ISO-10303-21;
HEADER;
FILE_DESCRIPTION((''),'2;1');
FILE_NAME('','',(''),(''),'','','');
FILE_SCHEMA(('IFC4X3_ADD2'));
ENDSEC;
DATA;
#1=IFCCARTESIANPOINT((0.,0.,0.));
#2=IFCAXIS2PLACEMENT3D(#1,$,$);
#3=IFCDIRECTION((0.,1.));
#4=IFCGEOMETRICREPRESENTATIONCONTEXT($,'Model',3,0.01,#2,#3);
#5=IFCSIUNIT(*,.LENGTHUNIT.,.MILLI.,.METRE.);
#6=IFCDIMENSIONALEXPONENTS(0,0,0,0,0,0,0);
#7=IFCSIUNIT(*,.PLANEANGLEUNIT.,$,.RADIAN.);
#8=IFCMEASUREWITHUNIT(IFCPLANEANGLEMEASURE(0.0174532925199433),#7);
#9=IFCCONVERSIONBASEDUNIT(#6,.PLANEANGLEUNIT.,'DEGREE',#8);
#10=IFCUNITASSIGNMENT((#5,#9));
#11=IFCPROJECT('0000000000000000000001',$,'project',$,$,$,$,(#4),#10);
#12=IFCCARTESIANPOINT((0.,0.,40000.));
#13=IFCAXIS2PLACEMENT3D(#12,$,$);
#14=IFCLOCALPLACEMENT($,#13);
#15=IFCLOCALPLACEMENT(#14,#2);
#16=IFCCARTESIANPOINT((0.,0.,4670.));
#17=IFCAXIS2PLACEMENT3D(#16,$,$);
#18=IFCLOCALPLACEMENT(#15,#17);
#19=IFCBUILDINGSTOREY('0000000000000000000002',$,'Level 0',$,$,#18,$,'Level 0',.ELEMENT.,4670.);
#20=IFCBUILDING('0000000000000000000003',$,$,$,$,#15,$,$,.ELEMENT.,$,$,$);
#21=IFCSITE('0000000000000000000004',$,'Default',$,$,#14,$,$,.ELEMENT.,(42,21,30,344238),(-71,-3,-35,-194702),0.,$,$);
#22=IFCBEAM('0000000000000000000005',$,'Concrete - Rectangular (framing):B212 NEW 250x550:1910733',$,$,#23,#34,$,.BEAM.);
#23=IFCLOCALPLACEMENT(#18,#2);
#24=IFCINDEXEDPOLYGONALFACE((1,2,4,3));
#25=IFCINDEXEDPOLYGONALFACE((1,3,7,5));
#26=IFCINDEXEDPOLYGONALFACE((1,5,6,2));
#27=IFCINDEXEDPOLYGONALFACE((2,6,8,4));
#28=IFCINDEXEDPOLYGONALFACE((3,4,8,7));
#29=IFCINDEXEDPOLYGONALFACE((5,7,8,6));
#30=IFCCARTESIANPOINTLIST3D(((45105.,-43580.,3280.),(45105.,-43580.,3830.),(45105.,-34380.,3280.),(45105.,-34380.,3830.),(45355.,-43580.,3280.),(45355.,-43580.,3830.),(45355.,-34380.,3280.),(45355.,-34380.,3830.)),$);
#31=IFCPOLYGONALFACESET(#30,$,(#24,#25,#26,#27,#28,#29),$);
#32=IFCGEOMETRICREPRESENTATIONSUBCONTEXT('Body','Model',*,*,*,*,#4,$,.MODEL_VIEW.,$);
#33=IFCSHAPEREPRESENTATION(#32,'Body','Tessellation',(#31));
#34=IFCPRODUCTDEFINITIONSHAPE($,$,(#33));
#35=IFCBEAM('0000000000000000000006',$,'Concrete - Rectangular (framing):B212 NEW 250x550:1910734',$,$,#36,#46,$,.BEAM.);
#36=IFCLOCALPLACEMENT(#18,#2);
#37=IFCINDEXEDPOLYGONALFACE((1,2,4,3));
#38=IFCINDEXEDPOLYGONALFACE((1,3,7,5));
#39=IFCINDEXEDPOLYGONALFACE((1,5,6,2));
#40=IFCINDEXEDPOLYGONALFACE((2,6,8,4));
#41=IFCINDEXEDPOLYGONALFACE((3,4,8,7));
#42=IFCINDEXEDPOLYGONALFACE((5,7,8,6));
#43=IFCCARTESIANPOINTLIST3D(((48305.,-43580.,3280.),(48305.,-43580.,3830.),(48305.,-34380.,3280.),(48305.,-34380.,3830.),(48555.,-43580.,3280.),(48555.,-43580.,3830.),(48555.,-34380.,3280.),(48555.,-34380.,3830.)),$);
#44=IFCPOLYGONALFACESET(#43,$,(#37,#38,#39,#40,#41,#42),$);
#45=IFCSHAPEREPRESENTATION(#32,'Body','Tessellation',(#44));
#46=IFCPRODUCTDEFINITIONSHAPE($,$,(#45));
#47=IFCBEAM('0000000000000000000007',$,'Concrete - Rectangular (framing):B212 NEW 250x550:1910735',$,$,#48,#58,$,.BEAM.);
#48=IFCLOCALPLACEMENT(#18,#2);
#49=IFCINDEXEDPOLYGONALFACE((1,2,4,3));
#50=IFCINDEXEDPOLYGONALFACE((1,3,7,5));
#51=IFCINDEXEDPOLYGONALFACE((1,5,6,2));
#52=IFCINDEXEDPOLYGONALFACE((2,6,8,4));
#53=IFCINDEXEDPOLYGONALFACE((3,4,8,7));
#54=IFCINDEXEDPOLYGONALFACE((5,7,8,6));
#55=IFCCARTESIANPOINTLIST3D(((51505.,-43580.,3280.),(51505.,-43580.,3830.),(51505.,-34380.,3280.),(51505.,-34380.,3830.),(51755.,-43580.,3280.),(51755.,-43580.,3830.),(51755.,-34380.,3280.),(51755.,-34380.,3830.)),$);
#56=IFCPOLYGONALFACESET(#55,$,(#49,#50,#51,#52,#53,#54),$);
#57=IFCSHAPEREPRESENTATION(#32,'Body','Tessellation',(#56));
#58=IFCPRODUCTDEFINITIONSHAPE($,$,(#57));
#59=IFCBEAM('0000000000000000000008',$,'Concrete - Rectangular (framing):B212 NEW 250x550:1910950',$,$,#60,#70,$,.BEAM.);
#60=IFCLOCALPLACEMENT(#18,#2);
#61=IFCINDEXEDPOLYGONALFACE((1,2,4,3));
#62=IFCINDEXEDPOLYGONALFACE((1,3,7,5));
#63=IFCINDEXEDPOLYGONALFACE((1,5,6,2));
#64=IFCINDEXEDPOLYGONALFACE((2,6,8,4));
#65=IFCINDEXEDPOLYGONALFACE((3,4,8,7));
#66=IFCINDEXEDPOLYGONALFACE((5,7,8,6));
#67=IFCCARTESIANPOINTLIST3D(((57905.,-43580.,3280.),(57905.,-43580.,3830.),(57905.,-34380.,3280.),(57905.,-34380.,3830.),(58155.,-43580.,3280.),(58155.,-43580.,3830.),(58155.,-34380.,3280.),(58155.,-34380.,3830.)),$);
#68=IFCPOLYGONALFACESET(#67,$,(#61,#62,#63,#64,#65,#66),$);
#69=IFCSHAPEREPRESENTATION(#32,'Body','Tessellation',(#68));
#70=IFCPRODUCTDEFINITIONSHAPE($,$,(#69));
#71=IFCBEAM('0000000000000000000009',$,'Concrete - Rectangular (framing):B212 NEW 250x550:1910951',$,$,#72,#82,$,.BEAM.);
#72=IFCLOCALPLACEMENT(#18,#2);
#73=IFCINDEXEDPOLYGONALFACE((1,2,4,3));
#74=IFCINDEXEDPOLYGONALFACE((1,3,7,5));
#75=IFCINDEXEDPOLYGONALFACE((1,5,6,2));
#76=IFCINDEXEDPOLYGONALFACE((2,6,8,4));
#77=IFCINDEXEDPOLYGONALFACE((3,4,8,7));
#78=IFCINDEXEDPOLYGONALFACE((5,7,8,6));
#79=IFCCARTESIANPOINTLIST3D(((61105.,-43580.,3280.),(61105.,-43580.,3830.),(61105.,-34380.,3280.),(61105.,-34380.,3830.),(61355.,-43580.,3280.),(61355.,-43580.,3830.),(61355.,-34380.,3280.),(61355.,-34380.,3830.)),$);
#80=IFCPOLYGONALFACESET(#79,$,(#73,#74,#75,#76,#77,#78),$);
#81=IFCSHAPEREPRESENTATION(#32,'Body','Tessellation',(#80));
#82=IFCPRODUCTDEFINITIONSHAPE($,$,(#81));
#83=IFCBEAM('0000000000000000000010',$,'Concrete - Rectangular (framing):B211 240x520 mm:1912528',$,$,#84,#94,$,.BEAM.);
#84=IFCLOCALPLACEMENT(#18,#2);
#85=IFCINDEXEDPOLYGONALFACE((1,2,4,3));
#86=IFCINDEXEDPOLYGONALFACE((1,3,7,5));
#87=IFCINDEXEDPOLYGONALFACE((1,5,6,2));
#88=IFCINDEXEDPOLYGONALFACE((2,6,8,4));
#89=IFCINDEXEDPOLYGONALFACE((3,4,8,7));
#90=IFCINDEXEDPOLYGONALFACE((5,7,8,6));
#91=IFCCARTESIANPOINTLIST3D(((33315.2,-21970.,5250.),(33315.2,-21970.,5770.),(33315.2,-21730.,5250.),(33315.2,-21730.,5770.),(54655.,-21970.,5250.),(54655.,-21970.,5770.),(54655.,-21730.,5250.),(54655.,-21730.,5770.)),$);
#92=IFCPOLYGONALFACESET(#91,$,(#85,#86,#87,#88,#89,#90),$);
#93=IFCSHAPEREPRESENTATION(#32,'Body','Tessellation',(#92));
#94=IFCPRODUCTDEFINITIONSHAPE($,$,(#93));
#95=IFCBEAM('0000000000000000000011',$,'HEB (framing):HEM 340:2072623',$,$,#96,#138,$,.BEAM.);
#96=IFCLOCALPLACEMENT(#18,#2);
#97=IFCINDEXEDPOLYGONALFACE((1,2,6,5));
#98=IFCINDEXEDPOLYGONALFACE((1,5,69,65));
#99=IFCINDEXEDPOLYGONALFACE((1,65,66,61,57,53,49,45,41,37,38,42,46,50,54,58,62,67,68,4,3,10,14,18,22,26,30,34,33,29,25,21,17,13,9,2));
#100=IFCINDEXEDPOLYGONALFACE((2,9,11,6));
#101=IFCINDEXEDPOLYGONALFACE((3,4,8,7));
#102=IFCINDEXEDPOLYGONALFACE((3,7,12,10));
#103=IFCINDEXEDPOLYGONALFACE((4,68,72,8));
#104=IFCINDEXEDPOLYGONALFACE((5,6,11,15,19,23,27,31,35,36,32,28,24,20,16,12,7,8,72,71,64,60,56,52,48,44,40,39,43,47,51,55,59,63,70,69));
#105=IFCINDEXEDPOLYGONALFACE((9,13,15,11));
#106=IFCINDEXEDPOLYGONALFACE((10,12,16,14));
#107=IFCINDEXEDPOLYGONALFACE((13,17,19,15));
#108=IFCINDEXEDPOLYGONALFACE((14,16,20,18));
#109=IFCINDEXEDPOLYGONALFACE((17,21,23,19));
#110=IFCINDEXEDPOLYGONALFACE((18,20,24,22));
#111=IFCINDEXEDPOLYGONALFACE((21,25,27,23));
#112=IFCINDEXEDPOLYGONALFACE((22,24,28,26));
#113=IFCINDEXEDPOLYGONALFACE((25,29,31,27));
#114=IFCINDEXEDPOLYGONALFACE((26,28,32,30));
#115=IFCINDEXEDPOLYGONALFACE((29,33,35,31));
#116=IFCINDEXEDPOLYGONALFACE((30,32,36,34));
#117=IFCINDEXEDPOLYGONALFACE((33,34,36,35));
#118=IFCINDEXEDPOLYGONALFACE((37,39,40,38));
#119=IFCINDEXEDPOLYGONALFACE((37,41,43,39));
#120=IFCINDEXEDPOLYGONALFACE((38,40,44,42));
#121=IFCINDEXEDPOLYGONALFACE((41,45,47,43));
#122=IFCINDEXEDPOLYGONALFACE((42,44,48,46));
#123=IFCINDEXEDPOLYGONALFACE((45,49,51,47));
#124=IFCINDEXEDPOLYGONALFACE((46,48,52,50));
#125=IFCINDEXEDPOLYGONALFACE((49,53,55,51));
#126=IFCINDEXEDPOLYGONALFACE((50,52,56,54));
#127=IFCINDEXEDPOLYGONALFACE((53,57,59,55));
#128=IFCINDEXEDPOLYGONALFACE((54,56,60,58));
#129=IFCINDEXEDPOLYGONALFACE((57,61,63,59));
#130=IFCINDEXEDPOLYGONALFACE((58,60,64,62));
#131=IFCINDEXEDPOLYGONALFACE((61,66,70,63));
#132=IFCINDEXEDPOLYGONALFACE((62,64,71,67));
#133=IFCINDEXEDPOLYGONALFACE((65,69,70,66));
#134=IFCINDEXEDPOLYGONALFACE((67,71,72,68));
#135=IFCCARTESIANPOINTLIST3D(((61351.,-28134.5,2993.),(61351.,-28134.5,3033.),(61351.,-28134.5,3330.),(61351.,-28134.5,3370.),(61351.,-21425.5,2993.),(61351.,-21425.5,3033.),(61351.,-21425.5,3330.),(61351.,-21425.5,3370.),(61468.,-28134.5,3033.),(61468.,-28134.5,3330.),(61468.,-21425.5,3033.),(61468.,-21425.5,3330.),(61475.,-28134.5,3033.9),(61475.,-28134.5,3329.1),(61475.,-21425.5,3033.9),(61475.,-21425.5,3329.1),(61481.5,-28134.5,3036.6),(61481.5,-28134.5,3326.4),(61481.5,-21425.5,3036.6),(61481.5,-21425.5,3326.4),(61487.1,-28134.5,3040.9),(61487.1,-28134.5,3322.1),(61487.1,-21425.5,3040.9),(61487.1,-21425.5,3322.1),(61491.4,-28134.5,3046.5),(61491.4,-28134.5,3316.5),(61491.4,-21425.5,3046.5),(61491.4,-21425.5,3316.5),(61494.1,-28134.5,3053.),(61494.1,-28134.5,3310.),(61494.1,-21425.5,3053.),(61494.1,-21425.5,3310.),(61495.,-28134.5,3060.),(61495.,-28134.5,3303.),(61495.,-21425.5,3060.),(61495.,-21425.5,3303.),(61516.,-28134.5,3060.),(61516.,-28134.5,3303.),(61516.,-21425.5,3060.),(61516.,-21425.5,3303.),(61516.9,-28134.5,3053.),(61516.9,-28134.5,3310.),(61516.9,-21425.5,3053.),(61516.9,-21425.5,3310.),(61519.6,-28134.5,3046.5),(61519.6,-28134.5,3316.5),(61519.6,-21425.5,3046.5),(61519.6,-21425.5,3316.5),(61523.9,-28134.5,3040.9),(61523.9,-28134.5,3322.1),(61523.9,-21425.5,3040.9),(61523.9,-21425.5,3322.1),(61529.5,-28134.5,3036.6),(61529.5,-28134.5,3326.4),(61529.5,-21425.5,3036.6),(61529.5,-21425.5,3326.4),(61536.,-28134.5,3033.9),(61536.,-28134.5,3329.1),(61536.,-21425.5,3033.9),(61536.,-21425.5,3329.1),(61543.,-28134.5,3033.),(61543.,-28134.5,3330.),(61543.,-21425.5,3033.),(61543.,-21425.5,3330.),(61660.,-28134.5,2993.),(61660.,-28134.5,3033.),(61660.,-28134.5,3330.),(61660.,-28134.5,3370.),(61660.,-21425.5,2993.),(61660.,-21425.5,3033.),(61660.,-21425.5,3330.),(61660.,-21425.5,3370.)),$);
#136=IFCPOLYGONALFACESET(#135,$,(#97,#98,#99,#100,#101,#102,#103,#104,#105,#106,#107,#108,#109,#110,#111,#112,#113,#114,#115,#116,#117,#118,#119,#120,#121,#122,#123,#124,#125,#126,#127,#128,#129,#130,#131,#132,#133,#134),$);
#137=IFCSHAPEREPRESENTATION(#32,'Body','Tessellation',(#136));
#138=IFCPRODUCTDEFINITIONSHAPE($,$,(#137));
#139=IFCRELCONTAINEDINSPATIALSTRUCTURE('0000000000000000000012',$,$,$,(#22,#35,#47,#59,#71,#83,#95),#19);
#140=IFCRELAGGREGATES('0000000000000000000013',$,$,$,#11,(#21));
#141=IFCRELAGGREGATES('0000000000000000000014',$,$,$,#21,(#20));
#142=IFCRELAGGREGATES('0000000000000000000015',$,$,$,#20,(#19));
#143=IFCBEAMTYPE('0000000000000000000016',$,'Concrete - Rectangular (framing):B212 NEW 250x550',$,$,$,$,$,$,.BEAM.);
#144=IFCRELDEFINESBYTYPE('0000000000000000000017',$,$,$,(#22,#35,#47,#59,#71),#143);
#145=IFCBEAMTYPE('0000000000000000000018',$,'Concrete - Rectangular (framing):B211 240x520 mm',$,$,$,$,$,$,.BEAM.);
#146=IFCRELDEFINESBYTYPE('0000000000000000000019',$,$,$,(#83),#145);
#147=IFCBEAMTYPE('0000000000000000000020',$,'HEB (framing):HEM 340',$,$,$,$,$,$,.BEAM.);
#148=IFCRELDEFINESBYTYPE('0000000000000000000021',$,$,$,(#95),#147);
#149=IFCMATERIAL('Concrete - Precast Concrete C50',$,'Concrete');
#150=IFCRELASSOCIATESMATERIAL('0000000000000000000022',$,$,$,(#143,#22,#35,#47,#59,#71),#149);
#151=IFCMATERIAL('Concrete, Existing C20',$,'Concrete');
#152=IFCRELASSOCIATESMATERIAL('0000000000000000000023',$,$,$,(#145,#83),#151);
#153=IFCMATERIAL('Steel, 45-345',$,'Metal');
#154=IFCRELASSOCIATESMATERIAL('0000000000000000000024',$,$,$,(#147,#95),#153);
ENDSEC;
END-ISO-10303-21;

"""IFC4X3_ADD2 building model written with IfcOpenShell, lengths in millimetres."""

from ifc_helpers import new_model, entity, si_unit, converted_unit, direction, frame, frame_2d, origin, origin_2d_with_axis, place, context, subcontext, project, spatial, polyline, circle_curve, parameter, trimmed, segment, composite_curve, rectangle, outline, extrude, source, transform, mapped, material, material_profile, profile_set, profile_usage, type_object, type_shapes, element, save


model = new_model("IFC4X3_ADD2")

# Units and contexts
model_context = context("Model", 3, precision=0.01, world=origin(), true_north=direction((0.0, 1.0)))
body_context = subcontext(model_context, "Body", "Model", "MODEL_VIEW")
ifc_project = project(units=[si_unit("LENGTHUNIT", "METRE", prefix="MILLI"), converted_unit("PLANEANGLEUNIT", "DEGREE", entity("IfcPlaneAngleMeasure", 0.0174532925199433), si_unit("PLANEANGLEUNIT", "RADIAN"), dimensions=[0, 0, 0, 0, 0, 0, 0])], contexts=[model_context])

# Site, building, storey
site_placement = place(None, frame((0.0, 0.0, 40000.0)))
site = spatial("IfcSite", under=ifc_project, at=site_placement, Name="Default", CompositionType="ELEMENT", RefLatitude=(42, 21, 30, 344238), RefLongitude=(-71, -3, -35, -194702), RefElevation=0.0)
building_placement = place(site_placement, origin())
building = spatial("IfcBuilding", under=site, at=building_placement, CompositionType="ELEMENT")
storey_placement = place(building_placement, frame((0.0, 0.0, 4670.0)))
storey = spatial("IfcBuildingStorey", under=building, at=storey_placement, Name="Level 0", LongName="Level 0", CompositionType="ELEMENT", Elevation=4670.0)

# Shared definitions
ifc_material_1 = material(Name="Steel, 45-345", Category="Metal")

# Beams
ifc_material_profile_1 = material_profile(ifc_material_1, outline(composite_curve([segment(polyline([(-154.5, -148.5), (-154.5, -188.5)]), True, "CONTINUOUS"), segment(polyline([(-154.5, -188.5), (154.5, -188.5)]), True, "CONTINUOUS"), segment(polyline([(154.5, -188.5), (154.5, -148.5)]), True, "CONTINUOUS"), segment(polyline([(154.5, -148.5), (37.5, -148.5)]), True, "CONTINUOUS"), segment(trimmed(circle_curve(frame_2d((37.5, -121.5), x_axis=(1.0, 0.0)), 27.0), [parameter(180.0)], [parameter(270.0)], True, "PARAMETER"), False, "CONTINUOUS"), segment(polyline([(10.5, -121.5), (10.5, 121.5)]), True, "CONTINUOUS"), segment(trimmed(circle_curve(frame_2d((37.5, 121.5), x_axis=(1.0, 0.0)), 27.0), [parameter(90.0)], [parameter(180.0)], True, "PARAMETER"), False, "CONTINUOUS"), segment(polyline([(37.5, 148.5), (154.5, 148.5)]), True, "CONTINUOUS"), segment(polyline([(154.5, 148.5), (154.5, 188.5)]), True, "CONTINUOUS"), segment(polyline([(154.5, 188.5), (-154.5, 188.5)]), True, "CONTINUOUS"), segment(polyline([(-154.5, 188.5), (-154.5, 148.5)]), True, "CONTINUOUS"), segment(polyline([(-154.5, 148.5), (-37.5, 148.5)]), True, "CONTINUOUS"), segment(trimmed(circle_curve(frame_2d((-37.5, 121.5), x_axis=(1.0, 0.0)), 27.0), [parameter(360.0)], [parameter(90.0)], True, "PARAMETER"), False, "CONTINUOUS"), segment(polyline([(-10.5, 121.5), (-10.5, -121.5)]), True, "CONTINUOUS"), segment(trimmed(circle_curve(frame_2d((-37.5, -121.5), x_axis=(1.0, 0.0)), 27.0), [parameter(270.0)], [parameter(0.0)], True, "PARAMETER"), False, "CONTINUOUS"), segment(polyline([(-37.5, -148.5), (-154.5, -148.5)]), True, "CONTINUOUS")], self_intersect=False)), Name="HEM 340")
ifc_profile_set_1 = profile_set([ifc_material_profile_1], Name="HEM 340")
ifc_profile_usage_1 = profile_usage(ifc_profile_set_1, cardinal=8)
ifc_material_2 = material(Name="Concrete - Precast Concrete C50", Category="Concrete")
ifc_material_profile_2 = material_profile(ifc_material_2, rectangle(XDim=9200.0, YDim=250.0, at=origin_2d_with_axis()), Name="B212 NEW 250x550")
ifc_profile_set_2 = profile_set([ifc_material_profile_2], Name="B212 NEW 250x550")
ifc_profile_usage_2 = profile_usage(ifc_profile_set_2, cardinal=8)
beam_type_1 = type_object("IfcBeamType", Name="Concrete - Rectangular (framing):B212 NEW 250x550", PredefinedType="BEAM", material=ifc_profile_set_2)
shared_shape_1 = source(origin(), body_context, "Body", "SweptSolid", [
    extrude(rectangle(XDim=9200.0, YDim=250.0, at=origin_2d_with_axis()), frame((0.0, 0.0, -275.0), z_axis=(0.0, 0.0, 1.0), x_axis=(-1.0, 0.0, 0.0)), (0.0, 0.0, 1.0), 550.0),
])
type_shapes(beam_type_1, [shared_shape_1])
for number, where, z_axis, x_axis, name in (
    (1, (45230.0, -38980.0, 3555.0), (0.0, 0.0, 1.0), (0.0, 1.0, 0.0), "Concrete - Rectangular (framing):B212 NEW 250x550:1910733"),
    (2, (48430.0, -38980.0, 3555.0), (0.0, 0.0, 1.0), (0.0, 1.0, 0.0), "Concrete - Rectangular (framing):B212 NEW 250x550:1910734"),
    (3, (51630.0, -38980.0, 3555.0), (0.0, 0.0, 1.0), (0.0, 1.0, 0.0), "Concrete - Rectangular (framing):B212 NEW 250x550:1910735"),
    (4, (58030.0, -38980.0, 3555.0), (0.0, 0.0, 1.0), (0.0, 1.0, 0.0), "Concrete - Rectangular (framing):B212 NEW 250x550:1910950"),
    (5, (61230.0, -38980.0, 3555.0), (0.0, 0.0, 1.0), (0.0, 1.0, 0.0), "Concrete - Rectangular (framing):B212 NEW 250x550:1910951"),
):
    element("IfcBeam", number, at=place(storey_placement, frame(where, z_axis=z_axis, x_axis=x_axis)), inside=storey, type_object=beam_type_1, material=ifc_profile_usage_2, Name=name, PredefinedType="BEAM", context=body_context, shape_type="MappedRepresentation", body=[
        mapped(shared_shape_1, transform((0.0, 0.0, 0.0), scale=1.0)),
    ])
ifc_material_3 = material(Name="Concrete, Existing C20", Category="Concrete")
ifc_material_profile_3 = material_profile(ifc_material_3, rectangle(XDim=21339.8, YDim=240.0, at=origin_2d_with_axis()), Name="B211 240x520 mm")
ifc_profile_set_3 = profile_set([ifc_material_profile_3], Name="B211 240x520 mm")
ifc_profile_usage_3 = profile_usage(ifc_profile_set_3, cardinal=8)
beam_type_2 = type_object("IfcBeamType", Name="Concrete - Rectangular (framing):B211 240x520 mm", PredefinedType="BEAM", material=ifc_profile_set_3)
shared_shape_2 = source(origin(), body_context, "Body", "SweptSolid", [
    extrude(rectangle(XDim=21339.8, YDim=240.0, at=origin_2d_with_axis()), frame((-60.1, 0.0, -260.0), z_axis=(0.0, 0.0, 1.0), x_axis=(-1.0, 0.0, 0.0)), (0.0, 0.0, 1.0), 520.0),
])
type_shapes(beam_type_2, [shared_shape_2])
beam_1_placement = place(storey_placement, frame((43925.0, -21850.0, 5510.0), z_axis=(0.0, 0.0, 1.0), x_axis=(-1.0, 0.0, 0.0)))
element("IfcBeam", 6, at=beam_1_placement, inside=storey, type_object=beam_type_2, material=ifc_profile_usage_3, Name="Concrete - Rectangular (framing):B211 240x520 mm:1912528", PredefinedType="BEAM", context=body_context, shape_type="MappedRepresentation", body=[
    mapped(shared_shape_2, transform((0.0, 0.0, 0.0), scale=1.0)),
])
beam_type_3 = type_object("IfcBeamType", Name="HEB (framing):HEM 340", PredefinedType="BEAM", material=ifc_profile_set_1)
shared_shape_3 = source(origin(), body_context, "Body", "SweptSolid", [
    extrude(outline(composite_curve([segment(polyline([(-154.5, -148.5), (-154.5, -188.5)]), True, "CONTINUOUS"), segment(polyline([(-154.5, -188.5), (154.5, -188.5)]), True, "CONTINUOUS"), segment(polyline([(154.5, -188.5), (154.5, -148.5)]), True, "CONTINUOUS"), segment(polyline([(154.5, -148.5), (37.5, -148.5)]), True, "CONTINUOUS"), segment(trimmed(circle_curve(frame_2d((37.5, -121.5), x_axis=(1.0, 0.0)), 27.0), [parameter(180.0)], [parameter(270.0)], True, "PARAMETER"), False, "CONTINUOUS"), segment(polyline([(10.5, -121.5), (10.5, 121.5)]), True, "CONTINUOUS"), segment(trimmed(circle_curve(frame_2d((37.5, 121.5), x_axis=(1.0, 0.0)), 27.0), [parameter(90.0)], [parameter(180.0)], True, "PARAMETER"), False, "CONTINUOUS"), segment(polyline([(37.5, 148.5), (154.5, 148.5)]), True, "CONTINUOUS"), segment(polyline([(154.5, 148.5), (154.5, 188.5)]), True, "CONTINUOUS"), segment(polyline([(154.5, 188.5), (-154.5, 188.5)]), True, "CONTINUOUS"), segment(polyline([(-154.5, 188.5), (-154.5, 148.5)]), True, "CONTINUOUS"), segment(polyline([(-154.5, 148.5), (-37.5, 148.5)]), True, "CONTINUOUS"), segment(trimmed(circle_curve(frame_2d((-37.5, 121.5), x_axis=(1.0, 0.0)), 27.0), [parameter(360.0)], [parameter(90.0)], True, "PARAMETER"), False, "CONTINUOUS"), segment(polyline([(-10.5, 121.5), (-10.5, -121.5)]), True, "CONTINUOUS"), segment(trimmed(circle_curve(frame_2d((-37.5, -121.5), x_axis=(1.0, 0.0)), 27.0), [parameter(270.0)], [parameter(0.0)], True, "PARAMETER"), False, "CONTINUOUS"), segment(polyline([(-37.5, -148.5), (-154.5, -148.5)]), True, "CONTINUOUS")], self_intersect=False)), frame((-3354.5, 0.0, 0.0), z_axis=(-1.0, 0.0, 0.0), x_axis=(0.0, -1.0, 0.0)), (0.0, 0.0, -1.0), 6709.0),
])
type_shapes(beam_type_3, [shared_shape_3])
beam_2_placement = place(storey_placement, frame((61505.5, -24780.0, 3181.5), z_axis=(0.0, 0.0, 1.0), x_axis=(0.0, -1.0, 0.0)))
element("IfcBeam", 7, at=beam_2_placement, inside=storey, type_object=beam_type_3, material=ifc_profile_usage_1, Name="HEB (framing):HEM 340:2072623", PredefinedType="BEAM", context=body_context, shape_type="MappedRepresentation", body=[
    mapped(shared_shape_3, transform((0.0, 0.0, 0.0), scale=1.0)),
])

save(model, "model.ifc")
